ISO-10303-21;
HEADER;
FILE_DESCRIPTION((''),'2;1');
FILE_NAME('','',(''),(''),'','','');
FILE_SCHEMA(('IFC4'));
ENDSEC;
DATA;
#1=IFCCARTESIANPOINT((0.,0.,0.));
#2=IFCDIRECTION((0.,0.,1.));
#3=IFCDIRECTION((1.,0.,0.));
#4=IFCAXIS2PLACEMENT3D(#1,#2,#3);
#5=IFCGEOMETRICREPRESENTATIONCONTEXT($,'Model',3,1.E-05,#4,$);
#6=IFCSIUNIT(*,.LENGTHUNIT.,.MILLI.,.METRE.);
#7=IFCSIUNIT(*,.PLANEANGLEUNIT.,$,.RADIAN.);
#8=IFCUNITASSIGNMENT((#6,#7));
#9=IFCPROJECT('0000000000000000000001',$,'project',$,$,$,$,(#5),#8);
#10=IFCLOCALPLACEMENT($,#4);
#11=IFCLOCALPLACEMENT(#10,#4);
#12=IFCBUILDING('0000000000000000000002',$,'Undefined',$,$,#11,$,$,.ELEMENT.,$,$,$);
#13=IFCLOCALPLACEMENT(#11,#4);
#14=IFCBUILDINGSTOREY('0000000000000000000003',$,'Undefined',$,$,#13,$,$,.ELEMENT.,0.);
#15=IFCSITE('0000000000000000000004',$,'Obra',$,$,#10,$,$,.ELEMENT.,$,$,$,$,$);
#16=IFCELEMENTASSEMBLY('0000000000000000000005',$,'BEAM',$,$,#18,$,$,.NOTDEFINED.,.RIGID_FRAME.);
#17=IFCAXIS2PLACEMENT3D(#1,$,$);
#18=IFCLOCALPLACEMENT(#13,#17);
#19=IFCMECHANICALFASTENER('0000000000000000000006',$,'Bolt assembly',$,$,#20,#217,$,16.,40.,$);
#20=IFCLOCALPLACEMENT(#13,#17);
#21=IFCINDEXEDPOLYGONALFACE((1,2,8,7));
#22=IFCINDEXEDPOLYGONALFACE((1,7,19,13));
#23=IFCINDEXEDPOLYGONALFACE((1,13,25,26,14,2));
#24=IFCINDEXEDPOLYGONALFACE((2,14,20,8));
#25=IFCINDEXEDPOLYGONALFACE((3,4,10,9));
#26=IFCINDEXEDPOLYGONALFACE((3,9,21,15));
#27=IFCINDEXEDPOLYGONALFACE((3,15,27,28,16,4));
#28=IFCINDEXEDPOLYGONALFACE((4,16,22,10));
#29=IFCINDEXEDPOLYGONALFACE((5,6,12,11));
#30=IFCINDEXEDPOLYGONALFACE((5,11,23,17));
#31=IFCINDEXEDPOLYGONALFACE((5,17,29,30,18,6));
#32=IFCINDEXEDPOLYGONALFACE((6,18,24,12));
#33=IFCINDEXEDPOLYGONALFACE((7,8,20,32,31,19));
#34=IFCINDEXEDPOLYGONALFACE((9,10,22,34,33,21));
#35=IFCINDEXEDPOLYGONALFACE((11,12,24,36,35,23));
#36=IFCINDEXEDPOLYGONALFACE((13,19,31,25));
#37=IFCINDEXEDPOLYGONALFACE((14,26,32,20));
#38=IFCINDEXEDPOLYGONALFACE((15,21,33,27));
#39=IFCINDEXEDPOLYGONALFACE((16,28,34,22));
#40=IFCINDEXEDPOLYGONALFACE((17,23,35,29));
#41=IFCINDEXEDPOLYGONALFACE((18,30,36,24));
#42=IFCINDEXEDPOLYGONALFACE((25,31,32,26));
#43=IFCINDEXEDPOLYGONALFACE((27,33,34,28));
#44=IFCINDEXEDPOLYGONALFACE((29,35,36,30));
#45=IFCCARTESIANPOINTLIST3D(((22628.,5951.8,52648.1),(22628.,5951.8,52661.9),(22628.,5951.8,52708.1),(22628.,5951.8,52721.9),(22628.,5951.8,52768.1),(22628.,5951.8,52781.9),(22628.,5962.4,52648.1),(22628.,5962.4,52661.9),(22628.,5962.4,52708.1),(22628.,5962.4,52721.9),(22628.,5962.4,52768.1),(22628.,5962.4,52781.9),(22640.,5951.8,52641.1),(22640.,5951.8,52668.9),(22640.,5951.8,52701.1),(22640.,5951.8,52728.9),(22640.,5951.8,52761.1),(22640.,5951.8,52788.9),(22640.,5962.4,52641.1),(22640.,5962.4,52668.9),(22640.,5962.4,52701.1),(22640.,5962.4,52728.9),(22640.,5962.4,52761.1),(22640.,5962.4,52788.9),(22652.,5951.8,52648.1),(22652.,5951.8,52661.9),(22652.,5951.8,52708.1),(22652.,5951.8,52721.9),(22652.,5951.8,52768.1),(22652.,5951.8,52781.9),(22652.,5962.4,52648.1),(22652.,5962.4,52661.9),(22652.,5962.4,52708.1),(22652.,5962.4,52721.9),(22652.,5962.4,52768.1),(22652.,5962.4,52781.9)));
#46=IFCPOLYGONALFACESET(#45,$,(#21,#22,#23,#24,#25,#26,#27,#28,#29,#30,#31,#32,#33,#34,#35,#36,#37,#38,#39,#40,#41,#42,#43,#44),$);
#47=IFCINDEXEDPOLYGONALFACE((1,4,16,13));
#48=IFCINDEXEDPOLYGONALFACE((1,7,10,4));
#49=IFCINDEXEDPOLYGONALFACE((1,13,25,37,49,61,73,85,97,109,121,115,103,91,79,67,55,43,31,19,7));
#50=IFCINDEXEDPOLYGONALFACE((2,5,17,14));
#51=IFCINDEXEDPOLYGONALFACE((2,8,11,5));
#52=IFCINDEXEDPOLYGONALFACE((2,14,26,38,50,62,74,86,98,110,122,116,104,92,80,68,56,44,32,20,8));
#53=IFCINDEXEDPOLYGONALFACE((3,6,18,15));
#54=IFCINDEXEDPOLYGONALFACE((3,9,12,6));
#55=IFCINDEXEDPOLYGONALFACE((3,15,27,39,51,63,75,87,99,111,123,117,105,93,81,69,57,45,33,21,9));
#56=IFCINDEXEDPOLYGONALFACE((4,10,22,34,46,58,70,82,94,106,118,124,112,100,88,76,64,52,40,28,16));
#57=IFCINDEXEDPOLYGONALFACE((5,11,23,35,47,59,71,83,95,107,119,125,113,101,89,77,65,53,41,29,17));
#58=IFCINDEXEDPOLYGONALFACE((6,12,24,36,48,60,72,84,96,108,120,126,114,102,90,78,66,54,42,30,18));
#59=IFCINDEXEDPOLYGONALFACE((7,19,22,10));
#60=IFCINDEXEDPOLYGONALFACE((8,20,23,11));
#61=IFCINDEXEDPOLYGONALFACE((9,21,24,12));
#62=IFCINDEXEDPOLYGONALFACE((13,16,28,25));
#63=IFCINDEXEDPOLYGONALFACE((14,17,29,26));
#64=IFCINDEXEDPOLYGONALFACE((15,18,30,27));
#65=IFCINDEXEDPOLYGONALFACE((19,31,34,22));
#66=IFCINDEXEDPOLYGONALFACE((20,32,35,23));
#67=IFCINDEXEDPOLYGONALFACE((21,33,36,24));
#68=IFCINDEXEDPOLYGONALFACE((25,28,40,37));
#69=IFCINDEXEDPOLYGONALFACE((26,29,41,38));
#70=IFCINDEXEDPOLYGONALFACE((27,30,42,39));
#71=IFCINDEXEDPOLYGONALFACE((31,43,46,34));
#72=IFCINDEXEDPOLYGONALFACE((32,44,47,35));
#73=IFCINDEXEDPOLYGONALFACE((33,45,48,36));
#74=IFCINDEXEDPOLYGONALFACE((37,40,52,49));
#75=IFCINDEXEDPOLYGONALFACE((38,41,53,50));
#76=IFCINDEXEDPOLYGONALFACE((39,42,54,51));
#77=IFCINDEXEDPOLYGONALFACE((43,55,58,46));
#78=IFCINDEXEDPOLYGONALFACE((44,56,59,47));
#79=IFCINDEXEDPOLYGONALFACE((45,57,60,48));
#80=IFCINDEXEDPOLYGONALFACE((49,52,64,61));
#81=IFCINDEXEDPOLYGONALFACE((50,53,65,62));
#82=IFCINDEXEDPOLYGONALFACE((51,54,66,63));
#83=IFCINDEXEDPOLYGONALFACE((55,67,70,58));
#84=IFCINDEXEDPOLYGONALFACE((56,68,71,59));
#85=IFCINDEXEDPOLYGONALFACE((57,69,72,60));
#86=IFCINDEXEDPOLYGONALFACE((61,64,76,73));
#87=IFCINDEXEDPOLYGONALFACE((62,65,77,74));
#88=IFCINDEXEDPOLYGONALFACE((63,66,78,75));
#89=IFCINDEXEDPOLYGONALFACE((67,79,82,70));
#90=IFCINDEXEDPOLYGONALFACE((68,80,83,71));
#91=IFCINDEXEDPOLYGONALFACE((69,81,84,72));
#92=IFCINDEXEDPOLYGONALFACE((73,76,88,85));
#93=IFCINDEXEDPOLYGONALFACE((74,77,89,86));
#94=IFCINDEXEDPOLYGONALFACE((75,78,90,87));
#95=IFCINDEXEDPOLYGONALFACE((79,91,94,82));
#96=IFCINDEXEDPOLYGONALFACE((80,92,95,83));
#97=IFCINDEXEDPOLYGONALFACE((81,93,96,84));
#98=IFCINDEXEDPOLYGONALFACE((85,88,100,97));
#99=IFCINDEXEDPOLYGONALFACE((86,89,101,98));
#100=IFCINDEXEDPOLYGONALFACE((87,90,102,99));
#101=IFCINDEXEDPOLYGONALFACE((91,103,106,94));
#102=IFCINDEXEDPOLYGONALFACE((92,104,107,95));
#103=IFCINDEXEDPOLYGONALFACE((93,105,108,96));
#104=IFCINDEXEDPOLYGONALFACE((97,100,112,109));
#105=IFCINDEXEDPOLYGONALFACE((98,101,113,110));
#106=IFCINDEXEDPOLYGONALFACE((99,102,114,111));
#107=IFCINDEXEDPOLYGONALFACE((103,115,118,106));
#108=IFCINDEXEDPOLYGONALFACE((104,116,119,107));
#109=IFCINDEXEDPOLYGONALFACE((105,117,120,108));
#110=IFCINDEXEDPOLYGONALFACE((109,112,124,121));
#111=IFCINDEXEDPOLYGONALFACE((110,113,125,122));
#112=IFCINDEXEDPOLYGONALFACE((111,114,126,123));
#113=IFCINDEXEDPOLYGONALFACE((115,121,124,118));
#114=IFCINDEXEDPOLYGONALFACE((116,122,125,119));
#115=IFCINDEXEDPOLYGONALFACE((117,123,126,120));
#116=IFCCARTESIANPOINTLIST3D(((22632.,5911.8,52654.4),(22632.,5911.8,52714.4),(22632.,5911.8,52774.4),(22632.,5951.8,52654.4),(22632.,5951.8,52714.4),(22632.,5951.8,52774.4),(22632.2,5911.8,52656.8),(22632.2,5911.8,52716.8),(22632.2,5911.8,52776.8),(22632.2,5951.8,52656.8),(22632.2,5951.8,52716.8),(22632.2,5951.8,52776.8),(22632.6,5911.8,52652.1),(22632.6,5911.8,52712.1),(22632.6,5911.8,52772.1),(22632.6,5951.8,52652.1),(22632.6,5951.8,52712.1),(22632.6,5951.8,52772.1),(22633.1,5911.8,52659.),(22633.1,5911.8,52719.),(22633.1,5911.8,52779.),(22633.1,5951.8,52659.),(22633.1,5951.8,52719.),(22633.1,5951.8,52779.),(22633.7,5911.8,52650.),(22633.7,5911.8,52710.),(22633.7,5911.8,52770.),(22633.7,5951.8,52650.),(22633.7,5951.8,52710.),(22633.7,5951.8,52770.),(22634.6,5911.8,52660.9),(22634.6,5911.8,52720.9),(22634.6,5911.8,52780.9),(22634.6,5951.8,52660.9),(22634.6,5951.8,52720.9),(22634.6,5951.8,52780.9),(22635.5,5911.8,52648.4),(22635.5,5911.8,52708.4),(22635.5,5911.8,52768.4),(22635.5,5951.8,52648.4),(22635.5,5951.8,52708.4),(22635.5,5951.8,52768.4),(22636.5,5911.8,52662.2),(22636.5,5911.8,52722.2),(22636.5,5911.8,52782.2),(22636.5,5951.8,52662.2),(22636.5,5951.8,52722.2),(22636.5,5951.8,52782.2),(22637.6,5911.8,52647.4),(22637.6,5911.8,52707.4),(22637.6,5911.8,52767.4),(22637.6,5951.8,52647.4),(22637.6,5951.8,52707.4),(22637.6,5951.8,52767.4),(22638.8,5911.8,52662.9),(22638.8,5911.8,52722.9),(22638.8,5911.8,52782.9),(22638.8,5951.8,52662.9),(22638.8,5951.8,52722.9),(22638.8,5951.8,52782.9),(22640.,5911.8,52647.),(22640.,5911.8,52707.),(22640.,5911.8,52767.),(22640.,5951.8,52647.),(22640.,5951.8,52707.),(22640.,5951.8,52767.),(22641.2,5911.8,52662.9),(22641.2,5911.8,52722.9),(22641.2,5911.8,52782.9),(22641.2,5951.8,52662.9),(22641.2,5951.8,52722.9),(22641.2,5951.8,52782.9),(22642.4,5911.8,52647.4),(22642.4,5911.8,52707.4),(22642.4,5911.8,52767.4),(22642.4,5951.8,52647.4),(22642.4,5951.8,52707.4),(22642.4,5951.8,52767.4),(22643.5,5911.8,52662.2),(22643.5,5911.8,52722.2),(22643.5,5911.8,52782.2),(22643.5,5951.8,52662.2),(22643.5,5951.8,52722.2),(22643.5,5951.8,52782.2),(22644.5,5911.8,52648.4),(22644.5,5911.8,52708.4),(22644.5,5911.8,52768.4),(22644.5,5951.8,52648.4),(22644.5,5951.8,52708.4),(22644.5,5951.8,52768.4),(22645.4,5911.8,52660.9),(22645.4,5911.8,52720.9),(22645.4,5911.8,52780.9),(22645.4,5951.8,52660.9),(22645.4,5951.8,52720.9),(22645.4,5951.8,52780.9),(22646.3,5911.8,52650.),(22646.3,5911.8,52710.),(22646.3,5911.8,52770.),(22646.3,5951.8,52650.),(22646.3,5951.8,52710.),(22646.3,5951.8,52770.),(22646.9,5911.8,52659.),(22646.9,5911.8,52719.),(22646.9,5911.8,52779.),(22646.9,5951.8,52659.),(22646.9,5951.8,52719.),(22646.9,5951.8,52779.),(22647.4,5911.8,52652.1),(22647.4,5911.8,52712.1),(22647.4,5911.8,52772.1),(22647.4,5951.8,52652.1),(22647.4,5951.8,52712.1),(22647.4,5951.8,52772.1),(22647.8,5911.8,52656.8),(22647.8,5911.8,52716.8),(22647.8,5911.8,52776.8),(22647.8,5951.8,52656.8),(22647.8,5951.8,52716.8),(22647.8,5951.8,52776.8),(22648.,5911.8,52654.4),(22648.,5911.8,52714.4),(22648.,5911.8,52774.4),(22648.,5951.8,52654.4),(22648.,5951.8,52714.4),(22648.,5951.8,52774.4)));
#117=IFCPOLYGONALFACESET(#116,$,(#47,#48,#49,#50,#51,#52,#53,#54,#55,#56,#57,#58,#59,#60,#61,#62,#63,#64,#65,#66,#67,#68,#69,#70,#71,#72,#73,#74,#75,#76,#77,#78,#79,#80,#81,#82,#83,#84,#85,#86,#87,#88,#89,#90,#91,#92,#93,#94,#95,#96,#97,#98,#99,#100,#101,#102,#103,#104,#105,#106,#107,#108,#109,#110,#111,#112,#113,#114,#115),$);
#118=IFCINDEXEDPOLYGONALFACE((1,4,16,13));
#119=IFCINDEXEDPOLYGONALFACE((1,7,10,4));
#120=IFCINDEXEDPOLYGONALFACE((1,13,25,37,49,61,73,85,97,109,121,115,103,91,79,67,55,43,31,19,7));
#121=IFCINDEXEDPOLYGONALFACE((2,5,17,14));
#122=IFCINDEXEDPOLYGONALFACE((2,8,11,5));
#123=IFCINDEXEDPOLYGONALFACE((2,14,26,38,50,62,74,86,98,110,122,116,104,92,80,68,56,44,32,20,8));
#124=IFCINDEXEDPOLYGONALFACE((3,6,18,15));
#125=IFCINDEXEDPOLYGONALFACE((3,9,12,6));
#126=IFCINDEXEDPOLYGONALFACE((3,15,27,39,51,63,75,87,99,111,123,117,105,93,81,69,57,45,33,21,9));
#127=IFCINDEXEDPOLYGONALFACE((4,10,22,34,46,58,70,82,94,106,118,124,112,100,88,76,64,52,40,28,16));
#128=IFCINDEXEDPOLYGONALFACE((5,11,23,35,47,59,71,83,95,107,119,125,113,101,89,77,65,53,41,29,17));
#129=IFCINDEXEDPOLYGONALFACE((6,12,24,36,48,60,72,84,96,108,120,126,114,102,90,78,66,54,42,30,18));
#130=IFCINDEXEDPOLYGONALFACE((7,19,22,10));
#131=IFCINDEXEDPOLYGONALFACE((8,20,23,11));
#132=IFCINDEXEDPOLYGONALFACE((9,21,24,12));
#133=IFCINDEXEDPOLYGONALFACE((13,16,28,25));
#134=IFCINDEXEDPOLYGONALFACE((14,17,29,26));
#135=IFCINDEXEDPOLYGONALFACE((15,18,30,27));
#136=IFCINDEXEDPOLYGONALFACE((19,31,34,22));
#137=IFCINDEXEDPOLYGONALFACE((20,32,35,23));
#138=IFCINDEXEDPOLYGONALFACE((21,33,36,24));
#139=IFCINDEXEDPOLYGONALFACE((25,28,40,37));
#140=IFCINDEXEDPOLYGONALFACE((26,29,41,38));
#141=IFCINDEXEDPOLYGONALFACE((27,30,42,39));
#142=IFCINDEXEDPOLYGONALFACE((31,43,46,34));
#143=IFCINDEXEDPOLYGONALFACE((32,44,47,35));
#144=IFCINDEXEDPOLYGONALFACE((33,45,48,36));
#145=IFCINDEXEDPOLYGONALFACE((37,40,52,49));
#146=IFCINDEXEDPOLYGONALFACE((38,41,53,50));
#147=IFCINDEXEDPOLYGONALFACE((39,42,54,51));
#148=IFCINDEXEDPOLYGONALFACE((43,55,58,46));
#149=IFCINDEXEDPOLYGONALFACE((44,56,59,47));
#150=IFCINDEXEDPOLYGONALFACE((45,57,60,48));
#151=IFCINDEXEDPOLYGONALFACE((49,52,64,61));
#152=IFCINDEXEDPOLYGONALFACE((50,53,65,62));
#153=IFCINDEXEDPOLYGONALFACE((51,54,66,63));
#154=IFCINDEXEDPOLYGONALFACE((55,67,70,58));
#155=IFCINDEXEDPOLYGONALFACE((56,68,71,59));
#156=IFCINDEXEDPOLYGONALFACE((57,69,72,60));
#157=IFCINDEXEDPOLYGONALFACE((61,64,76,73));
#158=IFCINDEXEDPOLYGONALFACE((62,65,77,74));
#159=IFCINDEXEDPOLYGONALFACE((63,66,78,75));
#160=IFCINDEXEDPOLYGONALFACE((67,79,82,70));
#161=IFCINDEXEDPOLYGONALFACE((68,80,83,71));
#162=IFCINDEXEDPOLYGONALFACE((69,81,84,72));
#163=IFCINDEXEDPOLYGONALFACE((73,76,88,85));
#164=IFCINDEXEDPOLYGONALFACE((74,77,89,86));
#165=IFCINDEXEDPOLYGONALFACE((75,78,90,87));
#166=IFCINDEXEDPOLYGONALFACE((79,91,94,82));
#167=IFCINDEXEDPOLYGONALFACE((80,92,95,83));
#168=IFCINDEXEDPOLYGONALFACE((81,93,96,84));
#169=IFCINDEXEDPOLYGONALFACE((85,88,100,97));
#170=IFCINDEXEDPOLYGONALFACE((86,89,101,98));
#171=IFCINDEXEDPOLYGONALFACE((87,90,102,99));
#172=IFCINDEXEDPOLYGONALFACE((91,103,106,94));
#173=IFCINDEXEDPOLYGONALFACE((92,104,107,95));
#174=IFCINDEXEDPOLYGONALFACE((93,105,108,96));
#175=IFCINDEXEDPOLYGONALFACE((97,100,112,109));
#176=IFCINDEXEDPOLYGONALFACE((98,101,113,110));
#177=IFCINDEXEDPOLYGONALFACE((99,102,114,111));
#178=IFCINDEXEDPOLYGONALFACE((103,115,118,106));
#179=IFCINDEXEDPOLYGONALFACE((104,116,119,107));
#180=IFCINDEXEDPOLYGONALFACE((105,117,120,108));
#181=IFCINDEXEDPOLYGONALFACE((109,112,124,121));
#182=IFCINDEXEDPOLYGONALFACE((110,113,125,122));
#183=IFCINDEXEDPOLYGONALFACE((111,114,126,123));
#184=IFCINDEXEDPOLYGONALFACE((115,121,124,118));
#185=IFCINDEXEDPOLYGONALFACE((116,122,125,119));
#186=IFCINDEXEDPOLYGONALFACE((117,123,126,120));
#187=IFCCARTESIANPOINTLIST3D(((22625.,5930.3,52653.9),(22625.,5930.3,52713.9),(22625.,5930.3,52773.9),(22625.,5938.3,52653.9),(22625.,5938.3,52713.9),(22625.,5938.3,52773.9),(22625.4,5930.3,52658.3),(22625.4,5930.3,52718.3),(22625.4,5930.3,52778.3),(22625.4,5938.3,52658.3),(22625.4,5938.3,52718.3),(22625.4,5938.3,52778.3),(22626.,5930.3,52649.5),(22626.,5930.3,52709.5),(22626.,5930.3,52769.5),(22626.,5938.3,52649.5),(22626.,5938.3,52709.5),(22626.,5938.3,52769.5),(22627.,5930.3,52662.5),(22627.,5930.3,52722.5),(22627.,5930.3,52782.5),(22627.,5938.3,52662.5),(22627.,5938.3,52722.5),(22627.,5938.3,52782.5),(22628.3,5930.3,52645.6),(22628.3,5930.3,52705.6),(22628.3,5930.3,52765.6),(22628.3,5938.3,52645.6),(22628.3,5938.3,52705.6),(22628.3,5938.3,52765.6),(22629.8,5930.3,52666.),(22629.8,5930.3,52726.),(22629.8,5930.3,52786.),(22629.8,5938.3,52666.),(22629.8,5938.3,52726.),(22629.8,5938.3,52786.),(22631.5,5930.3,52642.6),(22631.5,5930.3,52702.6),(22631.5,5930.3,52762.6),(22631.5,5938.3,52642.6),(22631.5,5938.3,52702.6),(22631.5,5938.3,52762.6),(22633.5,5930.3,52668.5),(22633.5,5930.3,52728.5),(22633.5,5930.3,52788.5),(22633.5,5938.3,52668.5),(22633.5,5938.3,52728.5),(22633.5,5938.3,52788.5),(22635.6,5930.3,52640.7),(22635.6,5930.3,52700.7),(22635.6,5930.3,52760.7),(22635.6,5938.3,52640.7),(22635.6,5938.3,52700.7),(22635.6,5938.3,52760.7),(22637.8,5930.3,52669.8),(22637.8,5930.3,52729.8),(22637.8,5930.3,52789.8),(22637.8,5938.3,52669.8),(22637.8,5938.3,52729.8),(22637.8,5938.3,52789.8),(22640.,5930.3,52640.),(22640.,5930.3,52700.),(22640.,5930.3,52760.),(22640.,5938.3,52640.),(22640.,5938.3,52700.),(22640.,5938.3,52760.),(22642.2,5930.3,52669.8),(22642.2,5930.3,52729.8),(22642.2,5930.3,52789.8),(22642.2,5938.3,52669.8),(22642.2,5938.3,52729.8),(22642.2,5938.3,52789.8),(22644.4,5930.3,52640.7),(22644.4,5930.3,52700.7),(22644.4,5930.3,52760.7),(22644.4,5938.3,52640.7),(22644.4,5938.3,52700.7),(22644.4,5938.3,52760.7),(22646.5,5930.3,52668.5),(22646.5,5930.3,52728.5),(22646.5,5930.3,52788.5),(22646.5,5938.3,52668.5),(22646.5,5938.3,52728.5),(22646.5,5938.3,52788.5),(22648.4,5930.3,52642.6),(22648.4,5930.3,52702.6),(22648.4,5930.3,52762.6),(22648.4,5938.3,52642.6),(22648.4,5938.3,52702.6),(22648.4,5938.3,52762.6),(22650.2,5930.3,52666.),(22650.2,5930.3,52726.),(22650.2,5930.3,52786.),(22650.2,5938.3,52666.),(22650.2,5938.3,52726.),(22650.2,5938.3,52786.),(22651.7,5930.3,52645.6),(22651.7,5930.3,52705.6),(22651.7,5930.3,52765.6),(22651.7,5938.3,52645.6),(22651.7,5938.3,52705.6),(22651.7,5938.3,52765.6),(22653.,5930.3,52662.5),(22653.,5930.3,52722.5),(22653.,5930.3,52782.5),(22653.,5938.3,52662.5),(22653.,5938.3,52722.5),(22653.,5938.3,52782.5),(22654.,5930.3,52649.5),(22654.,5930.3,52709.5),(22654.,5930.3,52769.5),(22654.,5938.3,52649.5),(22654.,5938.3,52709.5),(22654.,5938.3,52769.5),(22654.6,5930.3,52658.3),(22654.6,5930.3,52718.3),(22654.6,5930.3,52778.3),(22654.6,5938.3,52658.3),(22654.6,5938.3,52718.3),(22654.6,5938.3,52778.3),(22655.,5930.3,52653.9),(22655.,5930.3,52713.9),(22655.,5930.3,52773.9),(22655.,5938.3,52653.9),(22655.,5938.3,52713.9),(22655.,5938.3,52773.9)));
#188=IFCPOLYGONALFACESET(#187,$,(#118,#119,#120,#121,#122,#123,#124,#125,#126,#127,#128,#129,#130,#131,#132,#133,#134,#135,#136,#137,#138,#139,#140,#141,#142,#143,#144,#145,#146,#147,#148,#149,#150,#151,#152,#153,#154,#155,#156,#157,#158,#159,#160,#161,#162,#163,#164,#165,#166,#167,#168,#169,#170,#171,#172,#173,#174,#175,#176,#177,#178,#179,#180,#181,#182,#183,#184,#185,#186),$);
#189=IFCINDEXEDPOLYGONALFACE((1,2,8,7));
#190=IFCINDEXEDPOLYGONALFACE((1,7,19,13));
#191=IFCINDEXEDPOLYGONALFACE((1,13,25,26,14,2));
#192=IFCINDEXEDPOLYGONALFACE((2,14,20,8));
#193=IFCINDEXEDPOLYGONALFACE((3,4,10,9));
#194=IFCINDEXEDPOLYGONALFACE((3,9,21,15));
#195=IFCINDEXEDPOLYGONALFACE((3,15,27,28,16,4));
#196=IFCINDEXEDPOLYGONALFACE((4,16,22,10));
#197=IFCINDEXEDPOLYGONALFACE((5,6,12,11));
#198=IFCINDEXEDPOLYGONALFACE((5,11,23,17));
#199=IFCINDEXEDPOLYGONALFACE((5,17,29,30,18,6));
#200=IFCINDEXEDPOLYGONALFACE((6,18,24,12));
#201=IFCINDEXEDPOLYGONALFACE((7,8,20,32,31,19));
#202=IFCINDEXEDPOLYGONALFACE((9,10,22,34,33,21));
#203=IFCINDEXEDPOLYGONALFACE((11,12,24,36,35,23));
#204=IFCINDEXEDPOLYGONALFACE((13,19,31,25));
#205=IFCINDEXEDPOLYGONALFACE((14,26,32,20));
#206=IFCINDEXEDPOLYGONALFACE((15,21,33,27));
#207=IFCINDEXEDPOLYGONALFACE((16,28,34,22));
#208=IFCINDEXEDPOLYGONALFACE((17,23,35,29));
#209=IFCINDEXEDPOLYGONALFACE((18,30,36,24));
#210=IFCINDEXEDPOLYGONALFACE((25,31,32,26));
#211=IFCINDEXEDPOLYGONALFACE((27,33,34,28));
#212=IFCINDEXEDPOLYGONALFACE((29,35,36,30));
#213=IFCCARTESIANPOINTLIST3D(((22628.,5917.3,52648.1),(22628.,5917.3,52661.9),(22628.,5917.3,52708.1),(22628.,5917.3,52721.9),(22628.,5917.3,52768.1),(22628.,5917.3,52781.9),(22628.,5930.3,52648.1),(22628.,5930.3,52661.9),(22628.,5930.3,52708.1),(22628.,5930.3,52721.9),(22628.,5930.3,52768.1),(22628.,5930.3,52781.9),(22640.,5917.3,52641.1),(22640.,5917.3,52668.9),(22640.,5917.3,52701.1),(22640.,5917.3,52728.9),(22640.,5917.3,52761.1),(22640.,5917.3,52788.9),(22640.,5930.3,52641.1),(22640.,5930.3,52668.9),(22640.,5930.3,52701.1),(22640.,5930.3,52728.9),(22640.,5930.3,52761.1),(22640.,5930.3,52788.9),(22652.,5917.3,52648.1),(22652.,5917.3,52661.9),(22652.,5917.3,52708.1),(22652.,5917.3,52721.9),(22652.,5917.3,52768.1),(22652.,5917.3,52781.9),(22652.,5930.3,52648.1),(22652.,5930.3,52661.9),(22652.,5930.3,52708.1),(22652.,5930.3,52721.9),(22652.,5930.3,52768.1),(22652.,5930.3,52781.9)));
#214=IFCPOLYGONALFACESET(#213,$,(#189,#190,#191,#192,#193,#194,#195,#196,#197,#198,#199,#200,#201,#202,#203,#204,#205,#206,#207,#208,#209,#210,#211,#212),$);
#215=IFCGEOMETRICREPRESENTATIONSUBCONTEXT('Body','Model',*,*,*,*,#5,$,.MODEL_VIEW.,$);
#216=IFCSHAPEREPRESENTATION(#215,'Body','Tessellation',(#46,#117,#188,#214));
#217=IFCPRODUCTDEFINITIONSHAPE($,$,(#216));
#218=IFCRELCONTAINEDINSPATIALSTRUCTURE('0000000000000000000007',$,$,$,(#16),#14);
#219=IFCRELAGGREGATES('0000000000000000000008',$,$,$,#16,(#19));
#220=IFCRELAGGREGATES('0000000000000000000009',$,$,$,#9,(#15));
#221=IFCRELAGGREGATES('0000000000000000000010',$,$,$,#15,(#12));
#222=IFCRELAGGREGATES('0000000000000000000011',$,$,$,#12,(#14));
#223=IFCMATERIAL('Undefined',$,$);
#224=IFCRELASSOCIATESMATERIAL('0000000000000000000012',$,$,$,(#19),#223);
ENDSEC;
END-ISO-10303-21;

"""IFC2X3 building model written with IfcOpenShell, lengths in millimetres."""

from ifc_helpers import new_model, si_unit, frame, origin_with_axes, origin_2d_with_axis, place, context, subcontext, project, spatial, polyline, circle, outline, extrude, source, transform, mapped, material, element, aggregate, save


model = new_model("IFC2X3")

# Units and contexts
model_context = context("Model", 3, precision=1e-05, world=origin_with_axes())
body_context = subcontext(model_context, "Body", "Model", "MODEL_VIEW")
ifc_project = project(units=[si_unit("LENGTHUNIT", "METRE", prefix="MILLI"), si_unit("PLANEANGLEUNIT", "RADIAN")], contexts=[model_context])

# Site, building, storey
site_placement = place(None, origin_with_axes())
site = spatial("IfcSite", under=ifc_project, at=site_placement, Name="Obra", CompositionType="ELEMENT")
building_placement = place(site_placement, origin_with_axes())
building = spatial("IfcBuilding", under=site, at=building_placement, Name="Undefined", CompositionType="ELEMENT")
storey_placement = place(building_placement, origin_with_axes())
storey = spatial("IfcBuildingStorey", under=building, at=storey_placement, Name="Undefined", CompositionType="ELEMENT", Elevation=0.0)

# Element assembly
assembly_1_placement = place(storey_placement, origin_with_axes())
assembly_1 = element("IfcElementAssembly", 1, at=assembly_1_placement, inside=storey, Name="BEAM", AssemblyPlace="NOTDEFINED", PredefinedType="RIGID_FRAME")

# Mechanical fastener
ifc_material_1 = material(Name="Undefined")
shared_shape_1 = source(origin_with_axes(), body_context, "Body", "SweptSolid", [
    extrude(outline(polyline([(13.9, 0.0), (6.9, 12.0), (-6.9, 12.0), (-13.9, 0.0), (-6.9, -12.0), (6.9, -12.0), (13.9, 0.0)])), frame((0.0, -19.7, 0.0), z_axis=(0.0, 1.0, 0.0), x_axis=(1.0, 0.0, 0.0)), (0.0, 0.0, 1.0), 10.6),
    extrude(circle(Radius=8.0, at=origin_2d_with_axis()), frame((0.0, -9.1, 0.0), z_axis=(0.0, 1.0, 0.0), x_axis=(1.0, 0.0, 0.0)), (0.0, 0.0, 1.0), 40.0),
    extrude(circle(Radius=15.0, at=origin_2d_with_axis()), frame((0.0, 4.4, 0.0), z_axis=(0.0, 1.0, 0.0), x_axis=(1.0, 0.0, 0.0)), (0.0, 0.0, 1.0), 8.0),
    extrude(outline(polyline([(13.9, 0.0), (6.9, 12.0), (-6.9, 12.0), (-13.9, 0.0), (-6.9, -12.0), (6.9, -12.0), (13.9, 0.0)])), frame((0.0, 12.4, 0.0), z_axis=(0.0, 1.0, 0.0), x_axis=(1.0, 0.0, 0.0)), (0.0, 0.0, 1.0), 13.0),
])
mechanical_fastener_placement = place(assembly_1_placement, frame((22690.0, 5942.7, 52835.0), z_axis=(-1.0, 0.0, 0.0), x_axis=(0.0, 0.0, -1.0)))
mechanical_fastener = element("IfcMechanicalFastener", 2, at=mechanical_fastener_placement, material=ifc_material_1, Name="Bolt assembly", NominalDiameter=16.0, NominalLength=40.0, context=body_context, shape_type="MappedRepresentation", body=[
    mapped(shared_shape_1, transform((60.0, 0.0, 50.0))),
    mapped(shared_shape_1, transform((120.0, 0.0, 50.0))),
    mapped(shared_shape_1, transform((180.0, 0.0, 50.0))),
])
aggregate(assembly_1, [mechanical_fastener])

save(model, "model.ifc")
